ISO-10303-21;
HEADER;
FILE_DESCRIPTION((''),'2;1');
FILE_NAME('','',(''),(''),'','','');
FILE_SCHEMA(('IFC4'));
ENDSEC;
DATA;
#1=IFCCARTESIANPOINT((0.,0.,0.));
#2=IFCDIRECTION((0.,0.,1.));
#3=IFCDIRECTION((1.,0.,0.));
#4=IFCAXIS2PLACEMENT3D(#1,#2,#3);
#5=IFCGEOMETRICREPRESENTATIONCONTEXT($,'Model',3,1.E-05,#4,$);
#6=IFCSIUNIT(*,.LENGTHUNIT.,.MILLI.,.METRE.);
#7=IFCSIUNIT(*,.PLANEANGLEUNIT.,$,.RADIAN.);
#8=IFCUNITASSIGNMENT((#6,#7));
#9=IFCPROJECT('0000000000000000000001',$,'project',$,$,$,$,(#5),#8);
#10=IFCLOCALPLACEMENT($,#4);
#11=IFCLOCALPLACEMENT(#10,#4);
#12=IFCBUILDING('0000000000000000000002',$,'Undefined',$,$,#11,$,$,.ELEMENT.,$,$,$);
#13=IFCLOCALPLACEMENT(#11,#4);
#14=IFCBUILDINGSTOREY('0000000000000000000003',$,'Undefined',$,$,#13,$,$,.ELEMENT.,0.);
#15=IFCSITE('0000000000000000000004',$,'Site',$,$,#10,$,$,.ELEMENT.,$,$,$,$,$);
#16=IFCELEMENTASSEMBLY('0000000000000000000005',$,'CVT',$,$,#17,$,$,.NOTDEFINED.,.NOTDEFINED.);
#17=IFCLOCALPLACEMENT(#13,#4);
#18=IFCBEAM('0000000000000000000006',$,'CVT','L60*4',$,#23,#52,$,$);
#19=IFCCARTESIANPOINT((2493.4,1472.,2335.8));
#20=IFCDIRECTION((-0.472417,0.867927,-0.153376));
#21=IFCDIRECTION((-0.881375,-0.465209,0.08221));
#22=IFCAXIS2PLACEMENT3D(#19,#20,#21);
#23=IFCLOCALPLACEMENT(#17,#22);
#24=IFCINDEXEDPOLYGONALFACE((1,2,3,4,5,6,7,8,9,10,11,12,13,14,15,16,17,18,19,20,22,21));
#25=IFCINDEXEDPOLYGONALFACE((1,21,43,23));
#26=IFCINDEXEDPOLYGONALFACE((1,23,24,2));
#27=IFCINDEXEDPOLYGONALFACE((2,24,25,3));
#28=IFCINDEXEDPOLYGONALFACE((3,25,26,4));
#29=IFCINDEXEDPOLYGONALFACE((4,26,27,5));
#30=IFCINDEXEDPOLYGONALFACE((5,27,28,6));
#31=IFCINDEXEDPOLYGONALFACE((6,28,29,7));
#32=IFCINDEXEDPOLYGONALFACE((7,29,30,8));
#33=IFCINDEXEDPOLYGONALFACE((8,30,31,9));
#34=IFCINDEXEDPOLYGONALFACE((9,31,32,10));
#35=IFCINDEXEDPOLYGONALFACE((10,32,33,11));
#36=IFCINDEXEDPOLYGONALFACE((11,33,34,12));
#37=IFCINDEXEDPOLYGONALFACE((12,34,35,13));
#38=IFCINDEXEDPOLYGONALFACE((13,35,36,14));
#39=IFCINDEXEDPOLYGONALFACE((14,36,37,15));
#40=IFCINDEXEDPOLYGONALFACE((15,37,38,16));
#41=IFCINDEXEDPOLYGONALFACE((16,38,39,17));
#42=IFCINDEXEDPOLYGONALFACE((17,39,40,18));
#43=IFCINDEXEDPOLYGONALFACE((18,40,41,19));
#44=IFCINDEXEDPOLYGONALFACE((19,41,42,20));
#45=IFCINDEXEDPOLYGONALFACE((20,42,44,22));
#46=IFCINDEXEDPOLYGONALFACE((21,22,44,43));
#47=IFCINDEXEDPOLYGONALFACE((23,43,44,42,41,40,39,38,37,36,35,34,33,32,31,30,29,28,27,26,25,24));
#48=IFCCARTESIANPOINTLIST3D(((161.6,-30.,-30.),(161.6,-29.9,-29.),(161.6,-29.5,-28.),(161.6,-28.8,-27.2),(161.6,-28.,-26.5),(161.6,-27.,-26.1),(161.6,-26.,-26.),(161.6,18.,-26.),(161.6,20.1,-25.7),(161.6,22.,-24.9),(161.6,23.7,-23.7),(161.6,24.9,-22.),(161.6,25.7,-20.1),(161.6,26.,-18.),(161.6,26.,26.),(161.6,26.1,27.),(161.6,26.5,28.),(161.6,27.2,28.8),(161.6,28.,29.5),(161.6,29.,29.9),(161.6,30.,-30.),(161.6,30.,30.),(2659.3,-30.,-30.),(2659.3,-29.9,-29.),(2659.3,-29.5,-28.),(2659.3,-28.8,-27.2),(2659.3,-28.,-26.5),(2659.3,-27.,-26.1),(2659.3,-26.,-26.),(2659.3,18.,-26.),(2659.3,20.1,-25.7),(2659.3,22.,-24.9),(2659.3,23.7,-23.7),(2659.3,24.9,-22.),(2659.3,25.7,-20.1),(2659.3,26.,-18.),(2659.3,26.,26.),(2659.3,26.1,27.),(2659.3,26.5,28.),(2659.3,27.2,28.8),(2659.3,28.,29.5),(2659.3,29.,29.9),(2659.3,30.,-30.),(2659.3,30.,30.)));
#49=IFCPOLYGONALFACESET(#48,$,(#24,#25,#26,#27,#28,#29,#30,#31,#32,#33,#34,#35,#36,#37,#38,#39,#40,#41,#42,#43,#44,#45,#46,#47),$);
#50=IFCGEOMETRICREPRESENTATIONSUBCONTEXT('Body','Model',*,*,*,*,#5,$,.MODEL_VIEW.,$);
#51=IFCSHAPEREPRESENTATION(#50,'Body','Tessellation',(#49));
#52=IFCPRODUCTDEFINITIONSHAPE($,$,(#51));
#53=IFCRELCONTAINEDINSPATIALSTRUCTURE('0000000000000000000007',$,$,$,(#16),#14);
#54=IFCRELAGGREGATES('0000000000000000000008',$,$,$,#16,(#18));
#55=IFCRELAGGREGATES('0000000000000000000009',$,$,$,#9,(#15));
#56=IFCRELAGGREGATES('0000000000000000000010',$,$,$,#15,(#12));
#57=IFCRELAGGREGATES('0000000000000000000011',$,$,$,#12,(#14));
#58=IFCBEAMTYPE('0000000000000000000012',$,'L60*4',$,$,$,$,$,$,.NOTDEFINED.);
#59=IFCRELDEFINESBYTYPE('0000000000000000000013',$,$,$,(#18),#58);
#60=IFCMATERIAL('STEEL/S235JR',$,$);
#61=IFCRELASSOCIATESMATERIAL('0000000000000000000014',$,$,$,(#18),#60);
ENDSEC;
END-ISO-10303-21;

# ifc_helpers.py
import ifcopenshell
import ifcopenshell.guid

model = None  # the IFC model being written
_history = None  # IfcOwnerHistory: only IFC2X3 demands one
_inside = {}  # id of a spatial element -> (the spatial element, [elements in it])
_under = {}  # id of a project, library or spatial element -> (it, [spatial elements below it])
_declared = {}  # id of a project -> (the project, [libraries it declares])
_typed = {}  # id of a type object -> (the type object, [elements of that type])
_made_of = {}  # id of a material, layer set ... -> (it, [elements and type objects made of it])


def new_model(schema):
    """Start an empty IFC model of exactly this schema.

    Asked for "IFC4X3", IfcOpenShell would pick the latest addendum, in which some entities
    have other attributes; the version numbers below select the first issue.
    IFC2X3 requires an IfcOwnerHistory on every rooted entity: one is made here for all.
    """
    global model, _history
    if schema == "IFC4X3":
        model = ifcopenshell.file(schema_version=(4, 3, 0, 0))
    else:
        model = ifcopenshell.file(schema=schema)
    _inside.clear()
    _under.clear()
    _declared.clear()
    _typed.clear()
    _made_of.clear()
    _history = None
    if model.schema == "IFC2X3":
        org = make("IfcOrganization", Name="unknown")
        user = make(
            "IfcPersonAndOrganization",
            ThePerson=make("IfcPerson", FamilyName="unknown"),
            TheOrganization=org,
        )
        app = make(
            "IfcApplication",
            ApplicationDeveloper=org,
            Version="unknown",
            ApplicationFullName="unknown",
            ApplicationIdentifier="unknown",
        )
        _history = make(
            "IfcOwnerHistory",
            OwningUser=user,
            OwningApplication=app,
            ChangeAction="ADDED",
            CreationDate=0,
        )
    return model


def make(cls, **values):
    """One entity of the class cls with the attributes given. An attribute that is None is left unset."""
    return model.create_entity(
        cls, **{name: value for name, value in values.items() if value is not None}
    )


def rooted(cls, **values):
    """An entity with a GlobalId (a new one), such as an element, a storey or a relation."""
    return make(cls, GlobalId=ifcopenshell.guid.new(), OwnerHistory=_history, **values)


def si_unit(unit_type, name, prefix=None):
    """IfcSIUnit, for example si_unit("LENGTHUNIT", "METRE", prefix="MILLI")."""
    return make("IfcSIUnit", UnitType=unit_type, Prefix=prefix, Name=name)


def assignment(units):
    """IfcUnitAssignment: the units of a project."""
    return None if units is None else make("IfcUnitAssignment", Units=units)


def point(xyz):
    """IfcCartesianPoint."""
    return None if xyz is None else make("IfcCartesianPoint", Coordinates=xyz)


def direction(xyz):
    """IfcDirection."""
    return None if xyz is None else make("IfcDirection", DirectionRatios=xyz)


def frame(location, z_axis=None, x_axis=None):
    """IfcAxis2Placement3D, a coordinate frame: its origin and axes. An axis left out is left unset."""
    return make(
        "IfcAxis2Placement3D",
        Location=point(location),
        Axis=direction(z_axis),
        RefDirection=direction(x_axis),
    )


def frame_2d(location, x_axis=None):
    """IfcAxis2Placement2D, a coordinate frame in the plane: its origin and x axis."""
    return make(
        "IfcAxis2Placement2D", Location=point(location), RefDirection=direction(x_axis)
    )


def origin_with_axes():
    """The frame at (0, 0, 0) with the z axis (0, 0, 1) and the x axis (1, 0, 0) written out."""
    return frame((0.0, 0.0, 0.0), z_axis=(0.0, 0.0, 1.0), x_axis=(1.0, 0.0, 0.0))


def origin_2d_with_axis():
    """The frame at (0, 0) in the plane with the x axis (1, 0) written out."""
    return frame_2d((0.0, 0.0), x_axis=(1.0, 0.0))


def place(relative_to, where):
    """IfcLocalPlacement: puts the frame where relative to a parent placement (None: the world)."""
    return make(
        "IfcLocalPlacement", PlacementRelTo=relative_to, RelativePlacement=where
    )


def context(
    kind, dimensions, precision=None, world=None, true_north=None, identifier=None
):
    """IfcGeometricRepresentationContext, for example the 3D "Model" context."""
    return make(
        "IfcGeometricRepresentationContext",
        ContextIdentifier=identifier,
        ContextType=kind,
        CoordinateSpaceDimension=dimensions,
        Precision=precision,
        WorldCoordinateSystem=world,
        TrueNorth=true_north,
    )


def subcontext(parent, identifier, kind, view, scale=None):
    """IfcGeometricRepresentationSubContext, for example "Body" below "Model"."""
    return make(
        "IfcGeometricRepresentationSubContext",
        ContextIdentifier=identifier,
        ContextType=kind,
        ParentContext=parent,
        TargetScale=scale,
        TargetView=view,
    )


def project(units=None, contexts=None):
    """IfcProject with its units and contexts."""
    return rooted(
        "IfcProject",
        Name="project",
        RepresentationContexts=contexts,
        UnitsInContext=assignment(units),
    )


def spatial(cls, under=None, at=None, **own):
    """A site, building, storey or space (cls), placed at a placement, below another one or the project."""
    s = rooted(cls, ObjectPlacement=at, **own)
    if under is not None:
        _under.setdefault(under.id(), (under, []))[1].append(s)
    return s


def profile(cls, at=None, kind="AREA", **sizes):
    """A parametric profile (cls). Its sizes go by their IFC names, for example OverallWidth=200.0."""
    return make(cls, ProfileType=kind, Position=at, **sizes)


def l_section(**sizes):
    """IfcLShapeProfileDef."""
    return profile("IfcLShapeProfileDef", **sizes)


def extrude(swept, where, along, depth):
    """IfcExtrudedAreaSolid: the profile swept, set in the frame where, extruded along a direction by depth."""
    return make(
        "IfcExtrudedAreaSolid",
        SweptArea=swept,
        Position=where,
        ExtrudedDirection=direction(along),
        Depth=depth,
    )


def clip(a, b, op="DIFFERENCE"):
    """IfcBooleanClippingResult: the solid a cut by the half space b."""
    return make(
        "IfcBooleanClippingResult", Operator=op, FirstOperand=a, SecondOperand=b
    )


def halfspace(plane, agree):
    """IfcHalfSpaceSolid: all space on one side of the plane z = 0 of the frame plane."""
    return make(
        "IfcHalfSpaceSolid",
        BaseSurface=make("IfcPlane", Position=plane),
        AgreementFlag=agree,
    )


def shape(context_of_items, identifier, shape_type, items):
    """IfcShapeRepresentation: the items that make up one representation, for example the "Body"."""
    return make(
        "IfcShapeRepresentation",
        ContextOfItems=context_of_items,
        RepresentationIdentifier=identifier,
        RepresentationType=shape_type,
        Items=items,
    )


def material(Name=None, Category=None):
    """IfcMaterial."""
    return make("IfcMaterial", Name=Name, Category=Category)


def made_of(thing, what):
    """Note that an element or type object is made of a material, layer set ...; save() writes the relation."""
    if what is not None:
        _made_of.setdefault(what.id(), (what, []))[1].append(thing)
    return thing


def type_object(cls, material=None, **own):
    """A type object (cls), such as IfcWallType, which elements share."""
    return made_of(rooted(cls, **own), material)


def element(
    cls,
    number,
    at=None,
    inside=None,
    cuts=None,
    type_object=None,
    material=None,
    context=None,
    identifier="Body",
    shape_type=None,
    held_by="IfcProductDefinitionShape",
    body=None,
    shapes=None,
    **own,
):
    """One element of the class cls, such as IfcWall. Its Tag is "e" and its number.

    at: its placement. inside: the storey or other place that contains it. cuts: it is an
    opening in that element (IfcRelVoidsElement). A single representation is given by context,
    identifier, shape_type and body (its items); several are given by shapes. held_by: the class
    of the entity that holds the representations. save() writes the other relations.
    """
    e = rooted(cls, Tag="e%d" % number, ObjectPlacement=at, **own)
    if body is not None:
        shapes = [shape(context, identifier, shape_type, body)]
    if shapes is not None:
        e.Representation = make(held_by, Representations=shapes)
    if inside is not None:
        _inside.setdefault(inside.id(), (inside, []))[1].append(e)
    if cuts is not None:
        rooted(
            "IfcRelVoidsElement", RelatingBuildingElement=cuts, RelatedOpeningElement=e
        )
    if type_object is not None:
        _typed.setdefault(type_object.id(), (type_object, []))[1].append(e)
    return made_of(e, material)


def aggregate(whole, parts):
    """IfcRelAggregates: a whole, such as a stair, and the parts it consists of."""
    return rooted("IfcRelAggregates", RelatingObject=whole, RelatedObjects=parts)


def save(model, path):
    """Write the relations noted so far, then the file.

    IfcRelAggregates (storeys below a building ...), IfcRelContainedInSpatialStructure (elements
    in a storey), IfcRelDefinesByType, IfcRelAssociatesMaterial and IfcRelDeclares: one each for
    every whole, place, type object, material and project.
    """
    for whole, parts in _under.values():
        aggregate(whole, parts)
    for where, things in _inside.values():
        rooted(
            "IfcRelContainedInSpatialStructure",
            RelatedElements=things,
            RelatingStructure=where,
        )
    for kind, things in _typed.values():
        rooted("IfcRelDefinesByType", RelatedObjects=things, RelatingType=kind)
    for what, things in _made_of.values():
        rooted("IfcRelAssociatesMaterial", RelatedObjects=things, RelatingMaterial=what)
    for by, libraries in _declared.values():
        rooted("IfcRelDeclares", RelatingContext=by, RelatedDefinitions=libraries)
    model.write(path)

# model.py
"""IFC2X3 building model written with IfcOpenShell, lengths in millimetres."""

from ifc_helpers import new_model, si_unit, frame, origin_with_axes, origin_2d_with_axis, place, context, subcontext, project, spatial, l_section, extrude, clip, halfspace, material, type_object, element, aggregate, save


model = new_model("IFC2X3")

# Units and contexts
model_context = context("Model", 3, precision=1e-05, world=origin_with_axes())
body_context = subcontext(model_context, "Body", "Model", "MODEL_VIEW")
ifc_project = project(units=[si_unit("LENGTHUNIT", "METRE", prefix="MILLI"), si_unit("PLANEANGLEUNIT", "RADIAN")], contexts=[model_context])

# Site, building, storey
site_placement = place(None, origin_with_axes())
site = spatial("IfcSite", under=ifc_project, at=site_placement, Name="Site", CompositionType="ELEMENT")
building_placement = place(site_placement, origin_with_axes())
building = spatial("IfcBuilding", under=site, at=building_placement, Name="Undefined", CompositionType="ELEMENT")
storey_placement = place(building_placement, origin_with_axes())
storey = spatial("IfcBuildingStorey", under=building, at=storey_placement, Name="Undefined", CompositionType="ELEMENT", Elevation=0.0)

# Shared definitions
ifc_material_1 = material(Name="STEEL/S235JR")

# Element assembly, beam
assembly_1_placement = place(storey_placement, origin_with_axes())
assembly_1 = element("IfcElementAssembly", 1, at=assembly_1_placement, inside=storey, Name="CVT", AssemblyPlace="NOTDEFINED", PredefinedType="NOTDEFINED")
beam_type_1 = type_object("IfcBeamType", Name="L60*4", PredefinedType="NOTDEFINED")
beam_1_placement = place(assembly_1_placement, frame((2493.4, 1472.0, 2335.8), z_axis=(-0.472417, 0.867927, -0.153376), x_axis=(-0.881375, -0.465209, 0.08221)))
beam_1 = element("IfcBeam", 2, at=beam_1_placement, type_object=beam_type_1, material=ifc_material_1, Name="CVT", Description="L60*4", context=body_context, shape_type="Clipping", body=[
    clip(clip(extrude(l_section(Depth=60.0, Width=60.0, Thickness=4.0, FilletRadius=8.0, EdgeRadius=4.0, at=origin_2d_with_axis()), frame((2836.5, 0.0, 0.0), z_axis=(-1.0, 0.0, 0.0), x_axis=(0.0, -1.0, 0.0)), (0.0, 0.0, 1.0), 2836.5), halfspace(frame((2659.3, -30.0, -30.0), z_axis=(1.0, 0.0, 0.0), x_axis=(0.0, 0.0, 1.0)), False)), halfspace(frame((161.6, 30.0, -30.0), z_axis=(-1.0, 0.0, 0.0), x_axis=(0.0, 0.0, 1.0)), False)),
])

aggregate(assembly_1, [beam_1])

save(model, "model.ifc")
